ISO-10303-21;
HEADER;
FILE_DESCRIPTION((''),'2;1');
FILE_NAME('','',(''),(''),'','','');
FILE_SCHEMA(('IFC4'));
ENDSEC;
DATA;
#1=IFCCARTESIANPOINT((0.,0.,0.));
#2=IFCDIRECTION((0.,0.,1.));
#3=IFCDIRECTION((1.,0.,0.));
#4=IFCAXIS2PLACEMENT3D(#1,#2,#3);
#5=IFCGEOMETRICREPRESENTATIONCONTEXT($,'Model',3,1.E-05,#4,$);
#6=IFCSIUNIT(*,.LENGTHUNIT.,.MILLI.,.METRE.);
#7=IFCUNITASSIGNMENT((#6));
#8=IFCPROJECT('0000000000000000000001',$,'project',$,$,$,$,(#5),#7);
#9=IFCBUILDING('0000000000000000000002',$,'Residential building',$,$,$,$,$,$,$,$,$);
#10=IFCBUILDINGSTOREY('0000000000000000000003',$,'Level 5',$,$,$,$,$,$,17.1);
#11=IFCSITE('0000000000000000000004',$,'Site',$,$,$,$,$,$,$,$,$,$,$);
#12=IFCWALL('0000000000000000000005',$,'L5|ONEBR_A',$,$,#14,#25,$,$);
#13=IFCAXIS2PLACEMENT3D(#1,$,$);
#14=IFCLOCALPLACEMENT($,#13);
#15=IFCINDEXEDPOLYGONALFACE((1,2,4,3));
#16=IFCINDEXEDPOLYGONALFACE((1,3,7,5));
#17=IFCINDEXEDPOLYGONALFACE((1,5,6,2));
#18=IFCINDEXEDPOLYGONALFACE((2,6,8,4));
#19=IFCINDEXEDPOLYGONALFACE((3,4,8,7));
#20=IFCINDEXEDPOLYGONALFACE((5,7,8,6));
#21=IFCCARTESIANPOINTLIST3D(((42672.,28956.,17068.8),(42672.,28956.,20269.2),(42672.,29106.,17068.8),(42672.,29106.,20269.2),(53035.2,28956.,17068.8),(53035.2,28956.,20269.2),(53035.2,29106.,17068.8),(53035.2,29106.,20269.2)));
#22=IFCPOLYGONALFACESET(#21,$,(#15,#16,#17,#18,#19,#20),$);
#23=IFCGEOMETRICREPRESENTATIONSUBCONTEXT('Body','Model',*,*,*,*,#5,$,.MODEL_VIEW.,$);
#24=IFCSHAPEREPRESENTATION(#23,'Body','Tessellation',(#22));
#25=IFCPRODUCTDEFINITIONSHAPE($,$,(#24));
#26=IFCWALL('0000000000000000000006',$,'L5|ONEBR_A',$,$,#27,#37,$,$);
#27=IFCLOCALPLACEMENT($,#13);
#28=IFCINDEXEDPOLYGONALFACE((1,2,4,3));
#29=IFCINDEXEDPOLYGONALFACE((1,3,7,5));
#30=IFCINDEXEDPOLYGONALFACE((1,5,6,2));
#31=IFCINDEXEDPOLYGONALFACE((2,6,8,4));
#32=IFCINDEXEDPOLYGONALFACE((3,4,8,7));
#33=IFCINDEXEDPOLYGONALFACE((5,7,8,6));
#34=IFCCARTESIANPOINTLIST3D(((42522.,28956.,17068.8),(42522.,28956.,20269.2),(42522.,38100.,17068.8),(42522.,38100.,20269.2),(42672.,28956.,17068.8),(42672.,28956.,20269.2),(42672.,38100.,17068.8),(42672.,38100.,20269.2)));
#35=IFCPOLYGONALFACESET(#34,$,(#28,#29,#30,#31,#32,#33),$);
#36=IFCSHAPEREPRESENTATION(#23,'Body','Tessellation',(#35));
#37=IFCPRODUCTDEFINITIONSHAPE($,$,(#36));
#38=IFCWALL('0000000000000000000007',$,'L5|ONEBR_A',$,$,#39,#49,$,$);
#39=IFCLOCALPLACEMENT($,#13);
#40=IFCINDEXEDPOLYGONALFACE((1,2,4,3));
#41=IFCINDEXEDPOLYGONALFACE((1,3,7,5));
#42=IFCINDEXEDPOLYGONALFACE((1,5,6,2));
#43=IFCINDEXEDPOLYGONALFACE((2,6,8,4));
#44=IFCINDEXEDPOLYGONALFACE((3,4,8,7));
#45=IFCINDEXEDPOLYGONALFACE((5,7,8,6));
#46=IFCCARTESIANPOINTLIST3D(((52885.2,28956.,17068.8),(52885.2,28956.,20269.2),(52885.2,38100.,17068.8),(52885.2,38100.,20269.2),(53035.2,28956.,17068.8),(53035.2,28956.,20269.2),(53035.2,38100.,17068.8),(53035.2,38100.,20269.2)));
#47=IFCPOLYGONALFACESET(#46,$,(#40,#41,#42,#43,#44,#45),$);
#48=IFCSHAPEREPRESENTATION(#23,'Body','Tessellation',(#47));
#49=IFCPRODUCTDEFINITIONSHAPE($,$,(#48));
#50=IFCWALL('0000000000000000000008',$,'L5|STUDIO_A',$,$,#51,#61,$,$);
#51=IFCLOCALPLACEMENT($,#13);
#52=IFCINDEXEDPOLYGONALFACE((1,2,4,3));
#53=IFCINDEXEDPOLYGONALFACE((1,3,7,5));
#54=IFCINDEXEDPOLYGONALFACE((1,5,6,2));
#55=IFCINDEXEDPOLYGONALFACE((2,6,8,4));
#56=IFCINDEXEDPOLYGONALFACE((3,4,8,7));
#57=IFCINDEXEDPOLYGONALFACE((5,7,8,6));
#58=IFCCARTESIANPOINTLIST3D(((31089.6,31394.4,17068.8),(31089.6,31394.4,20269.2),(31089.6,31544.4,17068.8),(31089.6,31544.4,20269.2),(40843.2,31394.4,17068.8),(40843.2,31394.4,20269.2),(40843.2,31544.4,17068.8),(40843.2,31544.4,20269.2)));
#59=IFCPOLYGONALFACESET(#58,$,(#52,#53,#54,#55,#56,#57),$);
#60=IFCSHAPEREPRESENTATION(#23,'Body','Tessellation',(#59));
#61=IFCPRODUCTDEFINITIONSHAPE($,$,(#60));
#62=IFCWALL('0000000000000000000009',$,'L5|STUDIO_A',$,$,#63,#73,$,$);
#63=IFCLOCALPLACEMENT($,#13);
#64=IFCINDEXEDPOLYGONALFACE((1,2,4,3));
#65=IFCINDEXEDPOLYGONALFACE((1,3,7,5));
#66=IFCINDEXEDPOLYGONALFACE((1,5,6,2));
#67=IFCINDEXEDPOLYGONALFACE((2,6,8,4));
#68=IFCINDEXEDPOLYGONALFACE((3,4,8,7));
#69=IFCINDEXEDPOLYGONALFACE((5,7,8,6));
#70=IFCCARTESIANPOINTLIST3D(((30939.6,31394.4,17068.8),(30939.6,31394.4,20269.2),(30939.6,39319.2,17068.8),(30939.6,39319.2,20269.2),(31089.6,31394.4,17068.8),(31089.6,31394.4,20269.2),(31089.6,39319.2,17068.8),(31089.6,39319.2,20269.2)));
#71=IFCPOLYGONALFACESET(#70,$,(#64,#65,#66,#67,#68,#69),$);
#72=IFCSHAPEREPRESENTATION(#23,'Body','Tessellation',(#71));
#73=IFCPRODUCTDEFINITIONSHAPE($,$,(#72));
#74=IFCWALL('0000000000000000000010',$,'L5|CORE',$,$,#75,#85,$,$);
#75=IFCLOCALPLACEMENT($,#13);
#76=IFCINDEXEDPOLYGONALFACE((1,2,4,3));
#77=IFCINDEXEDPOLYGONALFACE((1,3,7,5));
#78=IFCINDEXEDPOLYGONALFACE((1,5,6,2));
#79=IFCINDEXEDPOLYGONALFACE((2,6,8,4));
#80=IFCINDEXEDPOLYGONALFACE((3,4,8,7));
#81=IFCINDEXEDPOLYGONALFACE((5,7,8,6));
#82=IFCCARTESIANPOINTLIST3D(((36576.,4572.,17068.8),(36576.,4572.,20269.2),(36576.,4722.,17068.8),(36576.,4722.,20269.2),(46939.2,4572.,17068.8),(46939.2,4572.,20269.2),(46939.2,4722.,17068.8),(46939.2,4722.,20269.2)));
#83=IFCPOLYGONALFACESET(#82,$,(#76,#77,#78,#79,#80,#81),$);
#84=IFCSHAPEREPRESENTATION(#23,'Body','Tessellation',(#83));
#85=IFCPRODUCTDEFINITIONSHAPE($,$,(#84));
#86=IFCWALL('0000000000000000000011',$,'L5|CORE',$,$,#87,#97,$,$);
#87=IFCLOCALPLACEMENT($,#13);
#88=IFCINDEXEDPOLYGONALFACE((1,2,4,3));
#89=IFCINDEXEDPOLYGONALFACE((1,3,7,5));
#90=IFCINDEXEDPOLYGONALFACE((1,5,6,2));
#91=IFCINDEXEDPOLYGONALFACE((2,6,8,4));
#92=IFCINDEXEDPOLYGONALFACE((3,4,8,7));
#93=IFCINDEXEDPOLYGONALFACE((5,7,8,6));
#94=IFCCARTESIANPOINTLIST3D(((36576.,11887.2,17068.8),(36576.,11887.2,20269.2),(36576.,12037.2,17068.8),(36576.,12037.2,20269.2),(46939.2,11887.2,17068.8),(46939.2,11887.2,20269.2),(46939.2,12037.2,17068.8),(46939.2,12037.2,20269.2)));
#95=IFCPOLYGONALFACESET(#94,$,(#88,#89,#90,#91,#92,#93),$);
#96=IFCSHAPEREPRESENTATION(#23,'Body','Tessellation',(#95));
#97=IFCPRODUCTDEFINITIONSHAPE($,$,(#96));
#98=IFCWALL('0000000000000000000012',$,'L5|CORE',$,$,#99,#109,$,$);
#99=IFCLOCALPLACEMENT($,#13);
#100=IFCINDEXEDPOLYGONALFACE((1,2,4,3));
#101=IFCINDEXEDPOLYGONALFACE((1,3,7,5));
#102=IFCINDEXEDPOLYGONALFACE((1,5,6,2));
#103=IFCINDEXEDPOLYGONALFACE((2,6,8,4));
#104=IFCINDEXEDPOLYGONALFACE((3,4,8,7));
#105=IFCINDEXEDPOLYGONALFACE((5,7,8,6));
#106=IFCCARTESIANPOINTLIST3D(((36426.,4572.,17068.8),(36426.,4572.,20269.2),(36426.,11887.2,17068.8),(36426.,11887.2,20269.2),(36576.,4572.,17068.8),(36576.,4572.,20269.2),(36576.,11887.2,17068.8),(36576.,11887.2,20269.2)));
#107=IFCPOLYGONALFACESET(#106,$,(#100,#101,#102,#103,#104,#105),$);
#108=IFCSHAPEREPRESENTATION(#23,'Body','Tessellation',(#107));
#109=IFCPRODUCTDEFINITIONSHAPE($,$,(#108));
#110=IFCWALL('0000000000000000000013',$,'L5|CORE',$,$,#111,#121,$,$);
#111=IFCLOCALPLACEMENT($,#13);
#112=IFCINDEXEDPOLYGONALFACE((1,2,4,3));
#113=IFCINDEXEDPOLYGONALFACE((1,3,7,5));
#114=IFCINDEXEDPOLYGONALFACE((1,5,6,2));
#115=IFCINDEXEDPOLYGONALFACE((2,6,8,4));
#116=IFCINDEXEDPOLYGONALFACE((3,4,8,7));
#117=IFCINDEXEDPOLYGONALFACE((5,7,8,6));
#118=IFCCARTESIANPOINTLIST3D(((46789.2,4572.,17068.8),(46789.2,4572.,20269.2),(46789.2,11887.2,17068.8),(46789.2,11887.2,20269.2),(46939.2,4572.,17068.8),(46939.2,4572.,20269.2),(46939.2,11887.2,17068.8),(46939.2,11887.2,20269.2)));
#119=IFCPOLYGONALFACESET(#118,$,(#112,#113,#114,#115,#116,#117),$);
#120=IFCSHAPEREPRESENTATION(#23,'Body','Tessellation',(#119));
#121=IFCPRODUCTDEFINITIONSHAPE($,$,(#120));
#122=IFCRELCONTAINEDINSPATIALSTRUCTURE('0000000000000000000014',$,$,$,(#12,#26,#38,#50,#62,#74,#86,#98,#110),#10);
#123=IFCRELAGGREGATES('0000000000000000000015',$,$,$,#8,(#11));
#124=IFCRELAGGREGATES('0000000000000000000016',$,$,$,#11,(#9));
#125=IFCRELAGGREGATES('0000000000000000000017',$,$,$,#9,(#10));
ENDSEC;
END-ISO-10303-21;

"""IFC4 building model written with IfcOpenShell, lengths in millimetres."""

from ifc_helpers import new_model, si_unit, frame, origin_with_axes, place, context, subcontext, project, spatial, indexed_curve, outline, extrude, element, save


model = new_model("IFC4")

# Units and contexts
model_context = context("Model", 3, precision=1e-05, world=origin_with_axes())
body_context = subcontext(model_context, "Body", "Model", "MODEL_VIEW")
ifc_project = project(units=[si_unit("LENGTHUNIT", "METRE", prefix="MILLI")], contexts=[model_context])

# Site, building, storey
site = spatial("IfcSite", under=ifc_project, Name="Site")
building = spatial("IfcBuilding", under=site, Name="Residential building")
storey = spatial("IfcBuildingStorey", under=building, Name="Level 5", Elevation=17.1)

# Walls
for number, where, z_axis, x_axis, name in (
    (1, (42672.0, 28956.0, 17068.8), (0.0, 0.0, 1.0), (1.0, 0.0, 0.0), "L5|ONEBR_A"),
):
    element("IfcWall", number, at=place(None, frame(where, z_axis=z_axis, x_axis=x_axis)), inside=storey, Name=name, context=body_context, shape_type="SweptSolid", body=[
        extrude(outline(indexed_curve([(0.0, 0.0), (0.0, 150.0), (10363.2, 150.0), (10363.2, 0.0), (0.0, 0.0)], self_intersect=False)), origin_with_axes(), (0.0, 0.0, 1.0), 3200.4),
    ])
for number, where, z_axis, x_axis, name in (
    (2, (42672.0, 28956.0, 17068.8), (0.0, 0.0, 1.0), (0.0, 1.0, 0.0), "L5|ONEBR_A"),
    (3, (53035.2, 28956.0, 17068.8), (0.0, 0.0, 1.0), (0.0, 1.0, 0.0), "L5|ONEBR_A"),
):
    element("IfcWall", number, at=place(None, frame(where, z_axis=z_axis, x_axis=x_axis)), inside=storey, Name=name, context=body_context, shape_type="SweptSolid", body=[
        extrude(outline(indexed_curve([(0.0, 0.0), (0.0, 150.0), (9144.0, 150.0), (9144.0, 0.0), (0.0, 0.0)], self_intersect=False)), origin_with_axes(), (0.0, 0.0, 1.0), 3200.4),
    ])
wall_1_placement = place(None, frame((31089.6, 31394.4, 17068.8), z_axis=(0.0, 0.0, 1.0), x_axis=(1.0, 0.0, 0.0)))
element("IfcWall", 4, at=wall_1_placement, inside=storey, Name="L5|STUDIO_A", context=body_context, shape_type="SweptSolid", body=[
    extrude(outline(indexed_curve([(0.0, 0.0), (0.0, 150.0), (9753.6, 150.0), (9753.6, 0.0), (0.0, 0.0)], self_intersect=False)), origin_with_axes(), (0.0, 0.0, 1.0), 3200.4),
])
wall_2_placement = place(None, frame((31089.6, 31394.4, 17068.8), z_axis=(0.0, 0.0, 1.0), x_axis=(0.0, 1.0, 0.0)))
element("IfcWall", 5, at=wall_2_placement, inside=storey, Name="L5|STUDIO_A", context=body_context, shape_type="SweptSolid", body=[
    extrude(outline(indexed_curve([(0.0, 0.0), (0.0, 150.0), (7924.8, 150.0), (7924.8, 0.0), (0.0, 0.0)], self_intersect=False)), origin_with_axes(), (0.0, 0.0, 1.0), 3200.4),
])
for number, where, z_axis, x_axis, name in (
    (6, (36576.0, 4572.0, 17068.8), (0.0, 0.0, 1.0), (1.0, 0.0, 0.0), "L5|CORE"),
    (7, (36576.0, 11887.2, 17068.8), (0.0, 0.0, 1.0), (1.0, 0.0, 0.0), "L5|CORE"),
):
    element("IfcWall", number, at=place(None, frame(where, z_axis=z_axis, x_axis=x_axis)), inside=storey, Name=name, context=body_context, shape_type="SweptSolid", body=[
        extrude(outline(indexed_curve([(0.0, 0.0), (0.0, 150.0), (10363.2, 150.0), (10363.2, 0.0), (0.0, 0.0)], self_intersect=False)), origin_with_axes(), (0.0, 0.0, 1.0), 3200.4),
    ])
for number, where, z_axis, x_axis, name in (
    (8, (36576.0, 4572.0, 17068.8), (0.0, 0.0, 1.0), (0.0, 1.0, 0.0), "L5|CORE"),
    (9, (46939.2, 4572.0, 17068.8), (0.0, 0.0, 1.0), (0.0, 1.0, 0.0), "L5|CORE"),
):
    element("IfcWall", number, at=place(None, frame(where, z_axis=z_axis, x_axis=x_axis)), inside=storey, Name=name, context=body_context, shape_type="SweptSolid", body=[
        extrude(outline(indexed_curve([(0.0, 0.0), (0.0, 150.0), (7315.2, 150.0), (7315.2, 0.0), (0.0, 0.0)], self_intersect=False)), origin_with_axes(), (0.0, 0.0, 1.0), 3200.4),
    ])

save(model, "model.ifc")
